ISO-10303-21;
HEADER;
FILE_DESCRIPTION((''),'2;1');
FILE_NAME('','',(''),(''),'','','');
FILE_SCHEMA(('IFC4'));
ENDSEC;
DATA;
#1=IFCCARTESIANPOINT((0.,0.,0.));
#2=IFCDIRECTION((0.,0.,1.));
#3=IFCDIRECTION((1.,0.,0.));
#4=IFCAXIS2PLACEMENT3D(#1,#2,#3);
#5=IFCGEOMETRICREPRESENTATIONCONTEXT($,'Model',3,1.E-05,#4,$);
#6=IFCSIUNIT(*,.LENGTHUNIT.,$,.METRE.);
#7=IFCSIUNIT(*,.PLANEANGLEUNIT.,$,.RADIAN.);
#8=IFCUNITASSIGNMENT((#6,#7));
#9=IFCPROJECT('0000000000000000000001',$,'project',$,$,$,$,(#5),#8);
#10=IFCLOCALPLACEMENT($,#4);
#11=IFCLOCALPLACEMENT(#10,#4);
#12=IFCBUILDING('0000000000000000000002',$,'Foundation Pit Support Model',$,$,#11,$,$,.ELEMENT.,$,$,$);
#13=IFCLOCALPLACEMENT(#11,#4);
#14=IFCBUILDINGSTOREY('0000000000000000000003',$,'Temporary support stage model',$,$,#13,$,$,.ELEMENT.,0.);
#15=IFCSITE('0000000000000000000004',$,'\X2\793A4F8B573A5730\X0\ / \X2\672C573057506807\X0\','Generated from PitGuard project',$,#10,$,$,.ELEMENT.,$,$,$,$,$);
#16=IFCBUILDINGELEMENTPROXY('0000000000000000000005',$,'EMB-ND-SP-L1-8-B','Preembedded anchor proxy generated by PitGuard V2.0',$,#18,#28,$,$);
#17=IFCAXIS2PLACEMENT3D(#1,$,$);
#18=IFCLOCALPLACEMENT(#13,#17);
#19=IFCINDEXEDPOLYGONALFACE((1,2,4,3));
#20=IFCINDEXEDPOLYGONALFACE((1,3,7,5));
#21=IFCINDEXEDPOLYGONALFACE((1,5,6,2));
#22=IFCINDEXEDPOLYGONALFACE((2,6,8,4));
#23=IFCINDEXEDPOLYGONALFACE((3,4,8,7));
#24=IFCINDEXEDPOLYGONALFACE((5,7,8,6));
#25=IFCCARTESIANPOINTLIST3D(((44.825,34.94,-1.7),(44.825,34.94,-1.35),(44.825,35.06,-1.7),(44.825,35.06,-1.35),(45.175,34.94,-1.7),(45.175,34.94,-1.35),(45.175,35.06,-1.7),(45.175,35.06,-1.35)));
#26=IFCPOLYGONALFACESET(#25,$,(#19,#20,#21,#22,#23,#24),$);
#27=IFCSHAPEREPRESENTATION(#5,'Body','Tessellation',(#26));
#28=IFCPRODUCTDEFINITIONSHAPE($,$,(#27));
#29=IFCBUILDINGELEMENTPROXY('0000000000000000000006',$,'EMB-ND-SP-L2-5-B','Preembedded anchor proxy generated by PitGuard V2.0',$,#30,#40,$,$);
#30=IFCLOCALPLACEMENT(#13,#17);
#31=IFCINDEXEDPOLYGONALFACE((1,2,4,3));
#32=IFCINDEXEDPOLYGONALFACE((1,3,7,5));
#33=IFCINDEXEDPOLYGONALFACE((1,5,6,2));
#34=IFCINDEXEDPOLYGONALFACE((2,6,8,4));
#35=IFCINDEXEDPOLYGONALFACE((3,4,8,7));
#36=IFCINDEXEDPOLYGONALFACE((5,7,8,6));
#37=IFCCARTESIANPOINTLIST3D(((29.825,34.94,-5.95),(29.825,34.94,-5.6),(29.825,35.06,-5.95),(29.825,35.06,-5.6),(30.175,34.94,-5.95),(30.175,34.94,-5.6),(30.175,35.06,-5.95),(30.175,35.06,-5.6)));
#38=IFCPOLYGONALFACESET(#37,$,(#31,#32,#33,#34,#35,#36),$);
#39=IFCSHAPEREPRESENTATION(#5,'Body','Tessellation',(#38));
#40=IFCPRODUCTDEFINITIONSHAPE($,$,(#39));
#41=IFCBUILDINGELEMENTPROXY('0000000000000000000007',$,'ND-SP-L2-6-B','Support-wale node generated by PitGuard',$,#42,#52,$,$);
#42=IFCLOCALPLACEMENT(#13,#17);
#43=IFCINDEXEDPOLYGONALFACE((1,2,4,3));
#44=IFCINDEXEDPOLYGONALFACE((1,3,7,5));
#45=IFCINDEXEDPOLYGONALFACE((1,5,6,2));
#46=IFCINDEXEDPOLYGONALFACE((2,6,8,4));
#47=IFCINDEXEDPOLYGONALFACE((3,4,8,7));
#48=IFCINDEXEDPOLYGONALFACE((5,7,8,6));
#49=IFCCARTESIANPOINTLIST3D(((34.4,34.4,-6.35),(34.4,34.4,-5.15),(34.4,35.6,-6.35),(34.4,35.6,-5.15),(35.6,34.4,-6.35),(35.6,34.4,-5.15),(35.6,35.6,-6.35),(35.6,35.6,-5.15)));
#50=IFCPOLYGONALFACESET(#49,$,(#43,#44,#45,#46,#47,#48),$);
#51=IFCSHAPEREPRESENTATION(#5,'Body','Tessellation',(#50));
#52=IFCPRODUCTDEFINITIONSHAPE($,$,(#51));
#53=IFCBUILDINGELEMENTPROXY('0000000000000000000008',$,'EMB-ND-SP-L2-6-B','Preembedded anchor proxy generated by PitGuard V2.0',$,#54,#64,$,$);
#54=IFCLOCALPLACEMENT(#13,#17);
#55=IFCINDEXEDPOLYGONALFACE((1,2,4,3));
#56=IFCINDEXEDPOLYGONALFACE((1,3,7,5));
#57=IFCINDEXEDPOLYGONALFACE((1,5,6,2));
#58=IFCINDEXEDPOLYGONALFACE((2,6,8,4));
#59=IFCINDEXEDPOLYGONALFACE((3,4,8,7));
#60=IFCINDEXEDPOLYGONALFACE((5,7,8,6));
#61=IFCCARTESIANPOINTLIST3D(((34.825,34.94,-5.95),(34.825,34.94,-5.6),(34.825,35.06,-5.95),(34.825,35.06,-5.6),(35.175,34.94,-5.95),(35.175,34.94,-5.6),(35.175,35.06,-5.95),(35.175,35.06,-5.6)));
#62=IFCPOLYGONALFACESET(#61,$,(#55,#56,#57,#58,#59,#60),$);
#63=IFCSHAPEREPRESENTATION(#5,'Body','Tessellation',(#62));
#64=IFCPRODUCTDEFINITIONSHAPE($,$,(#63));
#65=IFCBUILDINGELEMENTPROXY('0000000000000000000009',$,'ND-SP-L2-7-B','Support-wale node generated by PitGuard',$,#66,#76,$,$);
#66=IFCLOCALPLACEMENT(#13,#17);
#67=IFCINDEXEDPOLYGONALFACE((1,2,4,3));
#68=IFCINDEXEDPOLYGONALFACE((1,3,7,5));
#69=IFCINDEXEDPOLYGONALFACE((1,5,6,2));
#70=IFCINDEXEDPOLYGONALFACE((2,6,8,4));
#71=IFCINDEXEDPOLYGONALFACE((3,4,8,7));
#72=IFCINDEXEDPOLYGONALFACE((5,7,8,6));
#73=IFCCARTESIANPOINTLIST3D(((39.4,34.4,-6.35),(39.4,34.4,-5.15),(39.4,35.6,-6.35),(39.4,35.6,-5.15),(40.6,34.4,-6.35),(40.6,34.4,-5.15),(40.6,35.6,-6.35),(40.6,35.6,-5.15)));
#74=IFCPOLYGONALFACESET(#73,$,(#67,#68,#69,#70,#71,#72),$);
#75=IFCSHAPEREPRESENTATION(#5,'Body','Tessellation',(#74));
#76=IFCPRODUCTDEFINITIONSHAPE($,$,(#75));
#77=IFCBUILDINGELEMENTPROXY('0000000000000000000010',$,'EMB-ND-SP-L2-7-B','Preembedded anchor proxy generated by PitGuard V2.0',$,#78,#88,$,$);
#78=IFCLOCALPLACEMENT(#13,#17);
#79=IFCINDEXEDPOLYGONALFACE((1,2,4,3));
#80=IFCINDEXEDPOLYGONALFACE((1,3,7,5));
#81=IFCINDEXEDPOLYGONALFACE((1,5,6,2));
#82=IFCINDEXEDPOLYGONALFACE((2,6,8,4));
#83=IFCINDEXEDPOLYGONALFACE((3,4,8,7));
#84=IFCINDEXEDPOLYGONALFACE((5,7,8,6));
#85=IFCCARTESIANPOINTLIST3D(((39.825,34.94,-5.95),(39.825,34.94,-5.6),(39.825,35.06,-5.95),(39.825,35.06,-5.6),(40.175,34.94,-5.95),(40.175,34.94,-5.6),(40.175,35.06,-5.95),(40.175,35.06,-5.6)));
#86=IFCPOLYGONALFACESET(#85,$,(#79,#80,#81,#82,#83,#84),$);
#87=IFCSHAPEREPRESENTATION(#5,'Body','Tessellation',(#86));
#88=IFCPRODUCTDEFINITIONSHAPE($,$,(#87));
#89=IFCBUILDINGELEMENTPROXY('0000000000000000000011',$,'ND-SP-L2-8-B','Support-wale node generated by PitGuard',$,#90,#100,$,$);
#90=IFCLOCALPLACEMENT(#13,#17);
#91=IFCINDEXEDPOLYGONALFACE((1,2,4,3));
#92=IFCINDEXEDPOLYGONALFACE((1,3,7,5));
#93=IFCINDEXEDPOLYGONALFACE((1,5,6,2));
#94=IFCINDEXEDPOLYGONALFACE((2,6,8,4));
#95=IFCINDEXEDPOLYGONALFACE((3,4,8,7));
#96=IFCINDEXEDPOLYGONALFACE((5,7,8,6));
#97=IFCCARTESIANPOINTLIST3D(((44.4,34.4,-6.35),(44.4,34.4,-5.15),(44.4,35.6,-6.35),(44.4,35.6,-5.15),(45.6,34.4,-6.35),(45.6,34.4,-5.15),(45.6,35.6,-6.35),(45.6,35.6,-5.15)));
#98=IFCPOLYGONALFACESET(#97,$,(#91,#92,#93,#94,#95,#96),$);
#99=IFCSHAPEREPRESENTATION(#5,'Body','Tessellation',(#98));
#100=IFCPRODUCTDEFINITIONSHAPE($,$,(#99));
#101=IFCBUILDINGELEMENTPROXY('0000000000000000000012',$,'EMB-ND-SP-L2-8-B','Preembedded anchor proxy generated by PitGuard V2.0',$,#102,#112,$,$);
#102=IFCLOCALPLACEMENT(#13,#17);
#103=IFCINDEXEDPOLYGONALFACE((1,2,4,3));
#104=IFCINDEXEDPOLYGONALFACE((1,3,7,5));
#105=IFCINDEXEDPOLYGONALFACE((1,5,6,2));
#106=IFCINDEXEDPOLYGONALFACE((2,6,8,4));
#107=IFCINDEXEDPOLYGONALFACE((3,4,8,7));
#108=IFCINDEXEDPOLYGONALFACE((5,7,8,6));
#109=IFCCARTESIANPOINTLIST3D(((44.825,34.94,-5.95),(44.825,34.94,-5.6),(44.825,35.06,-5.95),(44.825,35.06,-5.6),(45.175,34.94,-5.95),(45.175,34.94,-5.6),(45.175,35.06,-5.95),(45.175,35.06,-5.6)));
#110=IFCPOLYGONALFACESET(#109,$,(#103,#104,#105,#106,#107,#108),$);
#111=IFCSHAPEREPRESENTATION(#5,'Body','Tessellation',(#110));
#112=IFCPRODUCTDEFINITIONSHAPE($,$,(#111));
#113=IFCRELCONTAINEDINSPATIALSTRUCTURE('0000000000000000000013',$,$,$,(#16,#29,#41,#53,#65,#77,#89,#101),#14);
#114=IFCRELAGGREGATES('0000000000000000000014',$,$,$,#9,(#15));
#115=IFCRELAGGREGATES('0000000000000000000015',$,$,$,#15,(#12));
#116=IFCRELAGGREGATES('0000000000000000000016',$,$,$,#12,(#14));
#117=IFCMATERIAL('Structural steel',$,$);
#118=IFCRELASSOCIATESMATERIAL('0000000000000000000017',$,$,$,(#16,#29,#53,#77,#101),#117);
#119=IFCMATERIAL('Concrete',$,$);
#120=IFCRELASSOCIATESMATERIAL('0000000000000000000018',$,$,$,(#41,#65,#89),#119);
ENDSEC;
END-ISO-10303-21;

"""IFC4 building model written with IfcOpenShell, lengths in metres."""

from ifc_helpers import new_model, si_unit, frame, origin_with_axes, origin_2d, place, context, project, spatial, rectangle, extrude, material, element, save


model = new_model("IFC4")

# Units and contexts
model_context = context("Model", 3, precision=1e-05, world=origin_with_axes())
ifc_project = project(units=[si_unit("LENGTHUNIT", "METRE"), si_unit("PLANEANGLEUNIT", "RADIAN")], contexts=[model_context])

# Site, building, storey
site_placement = place(None, origin_with_axes())
site = spatial("IfcSite", under=ifc_project, at=site_placement, Name="示例场地 / 本地坐标", Description="Generated from PitGuard project", CompositionType="ELEMENT")
building_placement = place(site_placement, origin_with_axes())
building = spatial("IfcBuilding", under=site, at=building_placement, Name="Foundation Pit Support Model", CompositionType="ELEMENT")
storey_placement = place(building_placement, origin_with_axes())
storey = spatial("IfcBuildingStorey", under=building, at=storey_placement, Name="Temporary support stage model", CompositionType="ELEMENT", Elevation=0.0)

# Shared definitions
ifc_material_1 = material(Name="Concrete")

# Shared definitions
ifc_material_2 = material(Name="Structural steel")

# Building element proxies
for number, where, z_axis, x_axis, name in (
    (1, (45.0, 35.0, -1.7), (0.0, 0.0, 1.0), (1.0, 0.0, 0.0), "EMB-ND-SP-L1-8-B"),
    (2, (30.0, 35.0, -5.95), (0.0, 0.0, 1.0), (1.0, 0.0, 0.0), "EMB-ND-SP-L2-5-B"),
):
    element("IfcBuildingElementProxy", number, at=place(storey_placement, frame(where, z_axis=z_axis, x_axis=x_axis)), inside=storey, material=ifc_material_2, Name=name, Description="Preembedded anchor proxy generated by PitGuard V2.0", context=model_context, shape_type="SweptSolid", body=[
        extrude(rectangle(XDim=0.35, YDim=0.12, at=origin_2d()), origin_with_axes(), (0.0, 0.0, 1.0), 0.35),
    ])
proxy_1_placement = place(storey_placement, frame((35.0, 35.0, -6.35), z_axis=(0.0, 0.0, 1.0), x_axis=(1.0, 0.0, 0.0)))
element("IfcBuildingElementProxy", 3, at=proxy_1_placement, inside=storey, material=ifc_material_1, Name="ND-SP-L2-6-B", Description="Support-wale node generated by PitGuard", context=model_context, shape_type="SweptSolid", body=[
    extrude(rectangle(XDim=1.2, YDim=1.2, at=origin_2d()), origin_with_axes(), (0.0, 0.0, 1.0), 1.2),
])
proxy_2_placement = place(storey_placement, frame((35.0, 35.0, -5.95), z_axis=(0.0, 0.0, 1.0), x_axis=(1.0, 0.0, 0.0)))
element("IfcBuildingElementProxy", 4, at=proxy_2_placement, inside=storey, material=ifc_material_2, Name="EMB-ND-SP-L2-6-B", Description="Preembedded anchor proxy generated by PitGuard V2.0", context=model_context, shape_type="SweptSolid", body=[
    extrude(rectangle(XDim=0.35, YDim=0.12, at=origin_2d()), origin_with_axes(), (0.0, 0.0, 1.0), 0.35),
])
proxy_3_placement = place(storey_placement, frame((40.0, 35.0, -6.35), z_axis=(0.0, 0.0, 1.0), x_axis=(1.0, 0.0, 0.0)))
element("IfcBuildingElementProxy", 5, at=proxy_3_placement, inside=storey, material=ifc_material_1, Name="ND-SP-L2-7-B", Description="Support-wale node generated by PitGuard", context=model_context, shape_type="SweptSolid", body=[
    extrude(rectangle(XDim=1.2, YDim=1.2, at=origin_2d()), origin_with_axes(), (0.0, 0.0, 1.0), 1.2),
])
proxy_4_placement = place(storey_placement, frame((40.0, 35.0, -5.95), z_axis=(0.0, 0.0, 1.0), x_axis=(1.0, 0.0, 0.0)))
element("IfcBuildingElementProxy", 6, at=proxy_4_placement, inside=storey, material=ifc_material_2, Name="EMB-ND-SP-L2-7-B", Description="Preembedded anchor proxy generated by PitGuard V2.0", context=model_context, shape_type="SweptSolid", body=[
    extrude(rectangle(XDim=0.35, YDim=0.12, at=origin_2d()), origin_with_axes(), (0.0, 0.0, 1.0), 0.35),
])
proxy_5_placement = place(storey_placement, frame((45.0, 35.0, -6.35), z_axis=(0.0, 0.0, 1.0), x_axis=(1.0, 0.0, 0.0)))
element("IfcBuildingElementProxy", 7, at=proxy_5_placement, inside=storey, material=ifc_material_1, Name="ND-SP-L2-8-B", Description="Support-wale node generated by PitGuard", context=model_context, shape_type="SweptSolid", body=[
    extrude(rectangle(XDim=1.2, YDim=1.2, at=origin_2d()), origin_with_axes(), (0.0, 0.0, 1.0), 1.2),
])
proxy_6_placement = place(storey_placement, frame((45.0, 35.0, -5.95), z_axis=(0.0, 0.0, 1.0), x_axis=(1.0, 0.0, 0.0)))
element("IfcBuildingElementProxy", 8, at=proxy_6_placement, inside=storey, material=ifc_material_2, Name="EMB-ND-SP-L2-8-B", Description="Preembedded anchor proxy generated by PitGuard V2.0", context=model_context, shape_type="SweptSolid", body=[
    extrude(rectangle(XDim=0.35, YDim=0.12, at=origin_2d()), origin_with_axes(), (0.0, 0.0, 1.0), 0.35),
])

save(model, "model.ifc")
